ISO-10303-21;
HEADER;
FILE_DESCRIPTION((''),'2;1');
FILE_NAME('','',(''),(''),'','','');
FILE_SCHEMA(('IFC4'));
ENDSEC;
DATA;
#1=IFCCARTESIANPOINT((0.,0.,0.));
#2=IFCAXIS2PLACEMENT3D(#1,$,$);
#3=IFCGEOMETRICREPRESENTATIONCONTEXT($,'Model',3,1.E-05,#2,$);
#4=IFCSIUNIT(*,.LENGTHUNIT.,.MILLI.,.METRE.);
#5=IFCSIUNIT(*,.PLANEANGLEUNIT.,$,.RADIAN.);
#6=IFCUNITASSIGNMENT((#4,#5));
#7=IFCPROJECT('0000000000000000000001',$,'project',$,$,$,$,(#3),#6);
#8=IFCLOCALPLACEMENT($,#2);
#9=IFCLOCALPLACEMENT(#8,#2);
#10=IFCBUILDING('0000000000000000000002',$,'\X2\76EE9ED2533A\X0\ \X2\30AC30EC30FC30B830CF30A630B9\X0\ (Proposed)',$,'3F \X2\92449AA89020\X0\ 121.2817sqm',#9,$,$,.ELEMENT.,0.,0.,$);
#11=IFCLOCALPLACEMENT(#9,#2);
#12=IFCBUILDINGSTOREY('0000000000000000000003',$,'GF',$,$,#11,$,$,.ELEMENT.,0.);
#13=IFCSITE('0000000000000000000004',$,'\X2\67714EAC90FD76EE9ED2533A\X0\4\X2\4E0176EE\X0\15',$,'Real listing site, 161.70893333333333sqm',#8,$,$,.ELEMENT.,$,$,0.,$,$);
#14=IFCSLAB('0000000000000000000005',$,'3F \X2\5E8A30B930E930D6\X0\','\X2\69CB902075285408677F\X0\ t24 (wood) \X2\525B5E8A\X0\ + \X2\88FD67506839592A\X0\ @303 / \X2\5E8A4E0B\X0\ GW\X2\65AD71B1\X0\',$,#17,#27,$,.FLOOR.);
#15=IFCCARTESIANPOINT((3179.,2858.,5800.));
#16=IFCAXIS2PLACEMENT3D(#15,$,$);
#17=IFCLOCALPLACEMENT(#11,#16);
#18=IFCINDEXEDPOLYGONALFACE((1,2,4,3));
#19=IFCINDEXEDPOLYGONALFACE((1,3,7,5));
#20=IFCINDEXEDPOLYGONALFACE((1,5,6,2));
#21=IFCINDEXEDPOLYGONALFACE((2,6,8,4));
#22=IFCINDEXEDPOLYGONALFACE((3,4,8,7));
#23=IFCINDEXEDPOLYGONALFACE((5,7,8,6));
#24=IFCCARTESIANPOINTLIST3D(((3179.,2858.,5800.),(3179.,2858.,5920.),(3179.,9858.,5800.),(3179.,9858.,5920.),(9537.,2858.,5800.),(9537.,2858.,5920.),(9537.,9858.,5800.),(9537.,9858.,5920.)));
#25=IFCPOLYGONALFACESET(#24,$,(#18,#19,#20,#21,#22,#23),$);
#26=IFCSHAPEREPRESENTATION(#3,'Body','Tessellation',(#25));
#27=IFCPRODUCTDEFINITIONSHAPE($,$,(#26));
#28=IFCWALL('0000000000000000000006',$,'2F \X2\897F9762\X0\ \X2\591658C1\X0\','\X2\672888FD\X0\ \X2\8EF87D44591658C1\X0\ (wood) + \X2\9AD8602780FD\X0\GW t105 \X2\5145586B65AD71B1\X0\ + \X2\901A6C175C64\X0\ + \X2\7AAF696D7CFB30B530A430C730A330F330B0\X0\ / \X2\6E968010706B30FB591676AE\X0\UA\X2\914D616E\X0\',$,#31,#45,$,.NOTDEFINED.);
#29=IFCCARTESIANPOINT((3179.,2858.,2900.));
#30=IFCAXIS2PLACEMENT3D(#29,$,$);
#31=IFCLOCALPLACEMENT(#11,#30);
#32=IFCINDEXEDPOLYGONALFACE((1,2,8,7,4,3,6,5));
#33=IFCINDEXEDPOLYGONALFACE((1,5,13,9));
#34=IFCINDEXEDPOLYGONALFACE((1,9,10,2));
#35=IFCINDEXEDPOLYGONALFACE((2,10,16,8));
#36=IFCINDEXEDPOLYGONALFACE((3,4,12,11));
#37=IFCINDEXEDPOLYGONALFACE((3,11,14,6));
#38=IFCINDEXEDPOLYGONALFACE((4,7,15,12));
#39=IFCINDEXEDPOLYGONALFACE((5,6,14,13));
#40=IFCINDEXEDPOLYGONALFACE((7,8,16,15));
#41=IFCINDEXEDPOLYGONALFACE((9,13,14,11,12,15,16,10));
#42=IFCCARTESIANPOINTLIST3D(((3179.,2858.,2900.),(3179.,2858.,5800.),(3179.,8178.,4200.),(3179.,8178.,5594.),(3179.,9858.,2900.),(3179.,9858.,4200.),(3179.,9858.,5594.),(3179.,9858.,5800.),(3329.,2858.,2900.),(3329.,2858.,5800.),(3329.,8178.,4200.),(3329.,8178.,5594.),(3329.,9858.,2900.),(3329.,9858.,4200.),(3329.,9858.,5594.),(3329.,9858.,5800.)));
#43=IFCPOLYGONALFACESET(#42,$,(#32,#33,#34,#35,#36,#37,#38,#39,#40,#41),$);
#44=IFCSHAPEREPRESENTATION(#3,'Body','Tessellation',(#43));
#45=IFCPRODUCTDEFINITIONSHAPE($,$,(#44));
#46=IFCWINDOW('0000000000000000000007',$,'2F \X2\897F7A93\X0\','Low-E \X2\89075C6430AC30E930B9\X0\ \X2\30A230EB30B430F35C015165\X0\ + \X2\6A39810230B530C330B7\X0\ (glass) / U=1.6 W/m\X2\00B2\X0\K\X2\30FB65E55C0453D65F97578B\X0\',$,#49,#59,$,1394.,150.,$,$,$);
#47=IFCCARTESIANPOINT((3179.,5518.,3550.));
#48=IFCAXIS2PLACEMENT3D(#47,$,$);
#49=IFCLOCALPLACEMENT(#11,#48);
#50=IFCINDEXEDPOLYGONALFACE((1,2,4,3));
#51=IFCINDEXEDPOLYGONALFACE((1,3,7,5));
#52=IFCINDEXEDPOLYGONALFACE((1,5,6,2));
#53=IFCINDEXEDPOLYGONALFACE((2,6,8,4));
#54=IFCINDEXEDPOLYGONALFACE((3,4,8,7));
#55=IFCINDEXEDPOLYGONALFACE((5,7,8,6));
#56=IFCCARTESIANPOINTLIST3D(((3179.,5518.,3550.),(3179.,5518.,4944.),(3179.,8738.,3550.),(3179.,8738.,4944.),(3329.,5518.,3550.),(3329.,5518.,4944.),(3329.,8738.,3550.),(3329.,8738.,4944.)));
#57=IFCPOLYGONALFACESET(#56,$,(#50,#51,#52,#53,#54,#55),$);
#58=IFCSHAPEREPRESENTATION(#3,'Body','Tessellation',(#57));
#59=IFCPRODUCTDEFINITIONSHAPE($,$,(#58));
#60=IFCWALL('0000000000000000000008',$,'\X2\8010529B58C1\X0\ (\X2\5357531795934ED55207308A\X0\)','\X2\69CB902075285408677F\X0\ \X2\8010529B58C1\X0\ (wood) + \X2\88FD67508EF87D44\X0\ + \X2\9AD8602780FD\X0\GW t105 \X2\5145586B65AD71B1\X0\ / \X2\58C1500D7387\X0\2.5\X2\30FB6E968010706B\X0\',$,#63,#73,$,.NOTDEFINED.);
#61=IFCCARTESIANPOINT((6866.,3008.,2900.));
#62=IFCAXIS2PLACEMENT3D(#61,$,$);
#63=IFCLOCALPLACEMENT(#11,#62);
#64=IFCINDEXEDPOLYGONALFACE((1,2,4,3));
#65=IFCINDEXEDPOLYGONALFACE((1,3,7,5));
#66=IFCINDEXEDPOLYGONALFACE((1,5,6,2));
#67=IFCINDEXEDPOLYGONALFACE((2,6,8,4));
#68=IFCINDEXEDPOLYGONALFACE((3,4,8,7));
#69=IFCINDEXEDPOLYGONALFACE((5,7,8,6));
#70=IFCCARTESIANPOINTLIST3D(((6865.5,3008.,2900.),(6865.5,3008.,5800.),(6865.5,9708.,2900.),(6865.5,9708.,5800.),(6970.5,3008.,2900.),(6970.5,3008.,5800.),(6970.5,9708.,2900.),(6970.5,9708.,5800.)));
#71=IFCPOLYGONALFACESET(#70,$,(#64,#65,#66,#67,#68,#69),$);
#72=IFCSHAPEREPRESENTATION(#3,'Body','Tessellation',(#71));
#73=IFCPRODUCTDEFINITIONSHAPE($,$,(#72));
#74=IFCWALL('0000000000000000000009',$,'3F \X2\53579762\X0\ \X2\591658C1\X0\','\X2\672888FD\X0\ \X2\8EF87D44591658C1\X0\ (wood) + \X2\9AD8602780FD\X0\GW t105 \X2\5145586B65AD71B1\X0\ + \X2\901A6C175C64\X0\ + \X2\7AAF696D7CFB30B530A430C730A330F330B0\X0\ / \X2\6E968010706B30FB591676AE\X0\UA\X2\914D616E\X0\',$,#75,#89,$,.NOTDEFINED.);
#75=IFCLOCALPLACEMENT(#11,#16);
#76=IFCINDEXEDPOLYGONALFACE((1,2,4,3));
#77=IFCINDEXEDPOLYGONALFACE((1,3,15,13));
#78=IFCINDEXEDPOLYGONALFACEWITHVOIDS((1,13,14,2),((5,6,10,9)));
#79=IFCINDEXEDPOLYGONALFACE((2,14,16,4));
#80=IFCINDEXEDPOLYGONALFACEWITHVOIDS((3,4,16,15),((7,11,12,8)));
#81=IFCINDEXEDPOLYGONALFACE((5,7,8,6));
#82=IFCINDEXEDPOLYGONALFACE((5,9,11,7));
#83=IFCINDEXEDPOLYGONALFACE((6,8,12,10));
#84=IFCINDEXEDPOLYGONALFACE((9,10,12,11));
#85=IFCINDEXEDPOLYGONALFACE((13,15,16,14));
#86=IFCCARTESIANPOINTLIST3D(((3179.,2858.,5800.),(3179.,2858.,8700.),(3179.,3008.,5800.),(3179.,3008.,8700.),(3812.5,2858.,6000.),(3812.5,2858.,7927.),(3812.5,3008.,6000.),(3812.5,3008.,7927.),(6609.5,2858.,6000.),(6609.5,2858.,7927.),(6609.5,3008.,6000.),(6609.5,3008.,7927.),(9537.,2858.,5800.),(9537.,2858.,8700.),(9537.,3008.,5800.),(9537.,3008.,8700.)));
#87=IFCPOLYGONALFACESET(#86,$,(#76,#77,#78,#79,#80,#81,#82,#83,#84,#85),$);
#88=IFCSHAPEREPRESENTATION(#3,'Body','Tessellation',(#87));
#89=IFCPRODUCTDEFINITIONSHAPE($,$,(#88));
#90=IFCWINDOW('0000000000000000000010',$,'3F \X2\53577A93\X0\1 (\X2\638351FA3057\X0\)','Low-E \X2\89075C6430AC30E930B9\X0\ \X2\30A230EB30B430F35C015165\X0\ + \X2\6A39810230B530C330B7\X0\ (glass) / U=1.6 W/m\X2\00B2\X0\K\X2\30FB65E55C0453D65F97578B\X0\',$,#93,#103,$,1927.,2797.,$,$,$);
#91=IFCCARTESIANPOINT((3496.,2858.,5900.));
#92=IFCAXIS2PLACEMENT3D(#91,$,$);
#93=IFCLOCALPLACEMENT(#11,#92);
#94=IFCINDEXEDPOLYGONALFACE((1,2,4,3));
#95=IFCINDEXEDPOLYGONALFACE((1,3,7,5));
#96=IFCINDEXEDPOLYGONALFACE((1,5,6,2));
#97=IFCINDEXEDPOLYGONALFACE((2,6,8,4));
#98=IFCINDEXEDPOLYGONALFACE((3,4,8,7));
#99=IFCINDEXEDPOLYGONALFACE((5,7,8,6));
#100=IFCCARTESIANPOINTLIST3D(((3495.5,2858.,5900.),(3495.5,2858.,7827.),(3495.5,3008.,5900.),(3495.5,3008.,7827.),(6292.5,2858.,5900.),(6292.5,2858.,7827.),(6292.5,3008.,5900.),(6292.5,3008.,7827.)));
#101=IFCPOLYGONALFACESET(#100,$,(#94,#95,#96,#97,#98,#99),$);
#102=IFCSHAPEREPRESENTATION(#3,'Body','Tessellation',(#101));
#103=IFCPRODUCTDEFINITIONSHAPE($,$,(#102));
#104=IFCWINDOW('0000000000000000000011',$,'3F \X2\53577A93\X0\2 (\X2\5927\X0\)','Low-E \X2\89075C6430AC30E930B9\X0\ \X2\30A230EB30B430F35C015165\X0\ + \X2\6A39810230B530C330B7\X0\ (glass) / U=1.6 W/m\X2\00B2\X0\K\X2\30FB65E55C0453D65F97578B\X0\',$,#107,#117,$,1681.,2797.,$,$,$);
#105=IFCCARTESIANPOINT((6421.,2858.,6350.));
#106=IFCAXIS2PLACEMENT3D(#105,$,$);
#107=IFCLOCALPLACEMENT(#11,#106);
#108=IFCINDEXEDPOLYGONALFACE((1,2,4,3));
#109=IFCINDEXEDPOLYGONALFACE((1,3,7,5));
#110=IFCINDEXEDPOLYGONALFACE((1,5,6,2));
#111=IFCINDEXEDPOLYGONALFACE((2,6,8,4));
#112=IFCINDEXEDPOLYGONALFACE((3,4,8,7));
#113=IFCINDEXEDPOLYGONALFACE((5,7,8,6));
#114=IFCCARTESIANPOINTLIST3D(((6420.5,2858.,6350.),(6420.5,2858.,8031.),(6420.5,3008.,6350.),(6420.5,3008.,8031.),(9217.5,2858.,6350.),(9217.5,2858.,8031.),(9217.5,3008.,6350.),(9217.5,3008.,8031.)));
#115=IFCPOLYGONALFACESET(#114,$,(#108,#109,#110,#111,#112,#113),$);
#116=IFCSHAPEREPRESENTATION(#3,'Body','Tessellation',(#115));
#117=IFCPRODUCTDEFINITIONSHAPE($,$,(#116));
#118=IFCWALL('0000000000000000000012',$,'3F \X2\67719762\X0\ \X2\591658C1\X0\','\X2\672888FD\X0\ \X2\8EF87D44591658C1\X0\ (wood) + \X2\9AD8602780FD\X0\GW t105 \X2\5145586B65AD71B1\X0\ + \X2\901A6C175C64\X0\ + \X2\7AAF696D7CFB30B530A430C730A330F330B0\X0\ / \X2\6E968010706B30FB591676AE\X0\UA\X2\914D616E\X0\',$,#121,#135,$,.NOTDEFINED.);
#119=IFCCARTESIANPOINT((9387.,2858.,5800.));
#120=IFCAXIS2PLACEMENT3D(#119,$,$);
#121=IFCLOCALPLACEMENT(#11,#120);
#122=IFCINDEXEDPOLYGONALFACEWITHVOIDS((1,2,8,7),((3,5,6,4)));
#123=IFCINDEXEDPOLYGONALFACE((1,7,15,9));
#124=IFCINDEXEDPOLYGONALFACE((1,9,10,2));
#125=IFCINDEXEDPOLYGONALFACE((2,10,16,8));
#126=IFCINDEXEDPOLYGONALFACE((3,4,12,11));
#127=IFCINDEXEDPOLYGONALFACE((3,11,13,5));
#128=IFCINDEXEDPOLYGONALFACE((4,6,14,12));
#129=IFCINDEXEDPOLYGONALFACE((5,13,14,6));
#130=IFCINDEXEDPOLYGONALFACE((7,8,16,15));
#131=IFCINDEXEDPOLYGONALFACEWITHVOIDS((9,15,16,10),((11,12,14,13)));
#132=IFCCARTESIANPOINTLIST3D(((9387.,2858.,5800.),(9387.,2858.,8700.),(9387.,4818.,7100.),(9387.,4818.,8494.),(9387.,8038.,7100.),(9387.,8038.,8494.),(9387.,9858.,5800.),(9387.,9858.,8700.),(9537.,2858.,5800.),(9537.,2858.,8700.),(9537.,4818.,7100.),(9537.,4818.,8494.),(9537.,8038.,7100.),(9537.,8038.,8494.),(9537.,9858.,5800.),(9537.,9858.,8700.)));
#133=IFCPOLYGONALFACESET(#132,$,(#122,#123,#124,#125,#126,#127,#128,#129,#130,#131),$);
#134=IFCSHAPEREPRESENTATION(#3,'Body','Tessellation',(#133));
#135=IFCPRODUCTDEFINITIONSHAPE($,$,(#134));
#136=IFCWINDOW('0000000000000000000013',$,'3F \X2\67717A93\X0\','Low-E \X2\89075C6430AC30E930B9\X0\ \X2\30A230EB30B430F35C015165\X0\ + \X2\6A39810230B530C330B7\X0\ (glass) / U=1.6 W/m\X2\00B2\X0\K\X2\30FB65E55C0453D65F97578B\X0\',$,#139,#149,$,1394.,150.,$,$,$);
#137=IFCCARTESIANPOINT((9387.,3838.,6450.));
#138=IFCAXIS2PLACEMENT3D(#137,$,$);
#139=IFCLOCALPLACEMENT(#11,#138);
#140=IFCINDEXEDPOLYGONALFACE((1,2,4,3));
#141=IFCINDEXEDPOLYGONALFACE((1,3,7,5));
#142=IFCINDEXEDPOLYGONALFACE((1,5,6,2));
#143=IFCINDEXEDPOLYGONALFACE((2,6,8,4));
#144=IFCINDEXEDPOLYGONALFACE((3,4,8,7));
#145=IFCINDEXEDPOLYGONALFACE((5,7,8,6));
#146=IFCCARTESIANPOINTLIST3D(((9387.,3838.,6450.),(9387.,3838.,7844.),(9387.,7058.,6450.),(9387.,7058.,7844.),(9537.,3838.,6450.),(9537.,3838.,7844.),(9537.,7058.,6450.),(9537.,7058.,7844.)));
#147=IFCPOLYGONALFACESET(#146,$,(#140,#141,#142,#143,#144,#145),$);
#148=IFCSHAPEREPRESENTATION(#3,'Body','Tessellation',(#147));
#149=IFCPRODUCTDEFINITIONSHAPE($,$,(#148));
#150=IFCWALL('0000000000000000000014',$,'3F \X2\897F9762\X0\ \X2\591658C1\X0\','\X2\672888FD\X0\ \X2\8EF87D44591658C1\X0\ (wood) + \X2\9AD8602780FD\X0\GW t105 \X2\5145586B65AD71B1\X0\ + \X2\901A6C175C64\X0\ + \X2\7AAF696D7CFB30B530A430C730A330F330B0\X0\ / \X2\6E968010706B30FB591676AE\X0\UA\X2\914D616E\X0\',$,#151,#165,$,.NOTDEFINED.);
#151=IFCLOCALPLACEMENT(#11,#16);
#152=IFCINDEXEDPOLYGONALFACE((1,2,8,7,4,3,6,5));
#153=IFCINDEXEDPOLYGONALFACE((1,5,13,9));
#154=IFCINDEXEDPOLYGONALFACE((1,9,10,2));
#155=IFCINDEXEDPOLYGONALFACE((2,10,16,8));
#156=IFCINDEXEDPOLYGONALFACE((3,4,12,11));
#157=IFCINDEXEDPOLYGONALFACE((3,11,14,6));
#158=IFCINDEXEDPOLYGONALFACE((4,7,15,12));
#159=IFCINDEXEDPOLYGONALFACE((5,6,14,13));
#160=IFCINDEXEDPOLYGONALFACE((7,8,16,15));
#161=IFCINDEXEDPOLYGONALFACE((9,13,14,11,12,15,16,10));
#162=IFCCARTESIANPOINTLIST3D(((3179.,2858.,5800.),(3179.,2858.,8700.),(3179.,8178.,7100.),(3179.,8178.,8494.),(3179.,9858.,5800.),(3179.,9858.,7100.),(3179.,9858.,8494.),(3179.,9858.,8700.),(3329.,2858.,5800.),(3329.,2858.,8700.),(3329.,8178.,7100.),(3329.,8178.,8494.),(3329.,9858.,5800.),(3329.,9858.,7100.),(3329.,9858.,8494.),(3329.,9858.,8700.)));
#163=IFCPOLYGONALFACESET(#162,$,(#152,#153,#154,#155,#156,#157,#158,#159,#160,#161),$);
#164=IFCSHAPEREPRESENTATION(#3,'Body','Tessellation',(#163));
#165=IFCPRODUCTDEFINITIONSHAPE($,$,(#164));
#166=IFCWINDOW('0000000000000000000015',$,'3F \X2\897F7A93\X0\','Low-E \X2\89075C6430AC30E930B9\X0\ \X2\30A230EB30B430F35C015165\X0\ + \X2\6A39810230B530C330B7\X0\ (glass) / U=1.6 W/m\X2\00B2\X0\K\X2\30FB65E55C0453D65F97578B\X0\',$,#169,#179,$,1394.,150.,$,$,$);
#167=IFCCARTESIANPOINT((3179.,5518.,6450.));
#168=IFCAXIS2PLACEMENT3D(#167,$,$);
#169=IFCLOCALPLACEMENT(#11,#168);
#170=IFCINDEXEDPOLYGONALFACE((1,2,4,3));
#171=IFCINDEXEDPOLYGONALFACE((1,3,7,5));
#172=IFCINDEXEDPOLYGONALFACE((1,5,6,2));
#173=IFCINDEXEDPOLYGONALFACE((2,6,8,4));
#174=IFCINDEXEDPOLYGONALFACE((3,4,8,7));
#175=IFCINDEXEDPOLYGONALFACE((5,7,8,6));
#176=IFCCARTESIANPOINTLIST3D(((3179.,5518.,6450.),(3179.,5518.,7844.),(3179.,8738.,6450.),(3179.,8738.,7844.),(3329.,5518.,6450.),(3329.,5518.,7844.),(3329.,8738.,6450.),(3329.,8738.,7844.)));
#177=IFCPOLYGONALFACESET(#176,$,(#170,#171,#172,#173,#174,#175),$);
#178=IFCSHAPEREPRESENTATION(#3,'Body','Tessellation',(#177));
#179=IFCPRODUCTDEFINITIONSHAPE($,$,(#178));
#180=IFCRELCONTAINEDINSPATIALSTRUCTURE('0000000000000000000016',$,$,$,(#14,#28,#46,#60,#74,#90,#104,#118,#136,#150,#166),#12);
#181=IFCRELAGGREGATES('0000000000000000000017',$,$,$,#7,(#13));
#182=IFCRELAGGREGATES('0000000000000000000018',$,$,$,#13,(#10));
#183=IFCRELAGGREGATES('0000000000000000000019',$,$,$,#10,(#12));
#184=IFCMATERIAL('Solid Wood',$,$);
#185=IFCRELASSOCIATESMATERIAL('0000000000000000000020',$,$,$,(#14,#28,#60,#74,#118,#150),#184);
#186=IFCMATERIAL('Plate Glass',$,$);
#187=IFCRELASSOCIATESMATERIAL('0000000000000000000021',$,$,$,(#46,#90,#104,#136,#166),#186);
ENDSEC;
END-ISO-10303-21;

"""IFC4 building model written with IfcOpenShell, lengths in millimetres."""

from ifc_helpers import new_model, si_unit, frame, frame_2d, origin, place, context, project, spatial, rectangle, extrude, material, element, fill, save


model = new_model("IFC4")

# Units and contexts
model_context = context("Model", 3, precision=1e-05, world=origin())
ifc_project = project(units=[si_unit("LENGTHUNIT", "METRE", prefix="MILLI"), si_unit("PLANEANGLEUNIT", "RADIAN")], contexts=[model_context])

# Site, building, storey
site_placement = place(None, origin())
site = spatial("IfcSite", under=ifc_project, at=site_placement, Name="東京都目黒区4丁目15", ObjectType="Real listing site, 161.70893333333333sqm", CompositionType="ELEMENT", RefElevation=0.0)
building_placement = place(site_placement, origin())
building = spatial("IfcBuilding", under=site, at=building_placement, Name="目黒区 ガレージハウス (Proposed)", ObjectType="3F 鉄骨造 121.2817sqm", CompositionType="ELEMENT", ElevationOfRefHeight=0.0, ElevationOfTerrain=0.0)
storey_placement = place(building_placement, origin())
storey = spatial("IfcBuildingStorey", under=building, at=storey_placement, Name="GF", CompositionType="ELEMENT", Elevation=0.0)

# Slab
ifc_material_1 = material(Name="Solid Wood")
slab_placement = place(storey_placement, frame((3179.0, 2858.0, 5800.0)))
element("IfcSlab", 1, at=slab_placement, inside=storey, material=ifc_material_1, Name="3F 床スラブ", Description="構造用合板 t24 (wood) 剛床 + 製材根太 @303 / 床下 GW断熱", PredefinedType="FLOOR", context=model_context, shape_type="SweptSolid", body=[
    extrude(rectangle(XDim=6358.0, YDim=7000.0, at=frame_2d((3179.0, 3500.0))), frame((3179.0, 2858.0, 5800.0)), (0.0, 0.0, 1.0), 120.0),
])

# Wall, opening, window
wall_1_placement = place(storey_placement, frame((3179.0, 2858.0, 2900.0)))
wall_1 = element("IfcWall", 2, at=wall_1_placement, inside=storey, material=ifc_material_1, Name="2F 西面 外壁", Description="木製 軸組外壁 (wood) + 高性能GW t105 充填断熱 + 通気層 + 窯業系サイディング / 準耐火・外皮UA配慮", PredefinedType="NOTDEFINED", context=model_context, shape_type="SweptSolid", body=[
    extrude(rectangle(XDim=150.0, YDim=7000.0, at=frame_2d((75.0, 3500.0))), frame((3179.0, 2858.0, 2900.0)), (0.0, 0.0, 1.0), 2900.0),
])
opening_1_placement = place(storey_placement, frame((3179.0, 5518.0, 3550.0)))
opening_1 = element("IfcOpeningElement", 3, at=opening_1_placement, cuts=wall_1, PredefinedType="NOTDEFINED", context=model_context, shape_type="SweptSolid", body=[
    extrude(rectangle(XDim=150.0, YDim=3220.0, at=frame_2d((75.0, 1610.0))), frame((3179.0, 5518.0, 3550.0)), (0.0, 0.0, 1.0), 1394.0),
])
ifc_material_2 = material(Name="Plate Glass")
window_1_placement = place(storey_placement, frame((3179.0, 5518.0, 3550.0)))
window_1 = element("IfcWindow", 4, at=window_1_placement, inside=storey, material=ifc_material_2, Name="2F 西窓", Description="Low-E 複層ガラス アルゴン封入 + 樹脂サッシ (glass) / U=1.6 W/m²K・日射取得型", OverallHeight=1394.0, OverallWidth=150.0, context=model_context, shape_type="SweptSolid", body=[
    extrude(rectangle(XDim=150.0, YDim=3220.0, at=frame_2d((75.0, 1610.0))), frame((3179.0, 5518.0, 3550.0)), (0.0, 0.0, 1.0), 1394.0),
])
fill(opening_1, window_1)

# Wall
wall_2_placement = place(storey_placement, frame((6866.0, 3008.0, 2900.0)))
element("IfcWall", 5, at=wall_2_placement, inside=storey, material=ifc_material_1, Name="耐力壁 (南北間仕切り)", Description="構造用合板 耐力壁 (wood) + 製材軸組 + 高性能GW t105 充填断熱 / 壁倍率2.5・準耐火", PredefinedType="NOTDEFINED", context=model_context, shape_type="SweptSolid", body=[
    extrude(rectangle(XDim=105.0, YDim=6700.0, at=frame_2d((52.0, 3350.0))), frame((6866.0, 3008.0, 2900.0)), (0.0, 0.0, 1.0), 2900.0),
])

# Wall, openings, windows
wall_3_placement = place(storey_placement, frame((3179.0, 2858.0, 5800.0)))
wall_3 = element("IfcWall", 6, at=wall_3_placement, inside=storey, material=ifc_material_1, Name="3F 南面 外壁", Description="木製 軸組外壁 (wood) + 高性能GW t105 充填断熱 + 通気層 + 窯業系サイディング / 準耐火・外皮UA配慮", PredefinedType="NOTDEFINED", context=model_context, shape_type="SweptSolid", body=[
    extrude(rectangle(XDim=6358.0, YDim=150.0, at=frame_2d((3179.0, 75.0))), frame((3179.0, 2858.0, 5800.0)), (0.0, 0.0, 1.0), 2900.0),
])
opening_2_placement = place(storey_placement, frame((3496.0, 2858.0, 5900.0)))
opening_2 = element("IfcOpeningElement", 7, at=opening_2_placement, cuts=wall_3, PredefinedType="NOTDEFINED", context=model_context, shape_type="SweptSolid", body=[
    extrude(rectangle(XDim=2797.0, YDim=150.0, at=frame_2d((1398.0, 75.0))), frame((3496.0, 2858.0, 5900.0)), (0.0, 0.0, 1.0), 1927.0),
])
opening_3_placement = place(storey_placement, frame((6421.0, 2858.0, 6350.0)))
opening_3 = element("IfcOpeningElement", 8, at=opening_3_placement, cuts=wall_3, PredefinedType="NOTDEFINED", context=model_context, shape_type="SweptSolid", body=[
    extrude(rectangle(XDim=2797.0, YDim=150.0, at=frame_2d((1398.0, 75.0))), frame((6421.0, 2858.0, 6350.0)), (0.0, 0.0, 1.0), 1681.0),
])
window_2_placement = place(storey_placement, frame((3496.0, 2858.0, 5900.0)))
window_2 = element("IfcWindow", 9, at=window_2_placement, inside=storey, material=ifc_material_2, Name="3F 南窓1 (掃出し)", Description="Low-E 複層ガラス アルゴン封入 + 樹脂サッシ (glass) / U=1.6 W/m²K・日射取得型", OverallHeight=1927.0, OverallWidth=2797.0, context=model_context, shape_type="SweptSolid", body=[
    extrude(rectangle(XDim=2797.0, YDim=150.0, at=frame_2d((1398.0, 75.0))), frame((3496.0, 2858.0, 5900.0)), (0.0, 0.0, 1.0), 1927.0),
])
fill(opening_2, window_2)
window_3_placement = place(storey_placement, frame((6421.0, 2858.0, 6350.0)))
window_3 = element("IfcWindow", 10, at=window_3_placement, inside=storey, material=ifc_material_2, Name="3F 南窓2 (大)", Description="Low-E 複層ガラス アルゴン封入 + 樹脂サッシ (glass) / U=1.6 W/m²K・日射取得型", OverallHeight=1681.0, OverallWidth=2797.0, context=model_context, shape_type="SweptSolid", body=[
    extrude(rectangle(XDim=2797.0, YDim=150.0, at=frame_2d((1398.0, 75.0))), frame((6421.0, 2858.0, 6350.0)), (0.0, 0.0, 1.0), 1681.0),
])
fill(opening_3, window_3)

# Walls, openings, windows
wall_4_placement = place(storey_placement, frame((9387.0, 2858.0, 5800.0)))
wall_4 = element("IfcWall", 11, at=wall_4_placement, inside=storey, material=ifc_material_1, Name="3F 東面 外壁", Description="木製 軸組外壁 (wood) + 高性能GW t105 充填断熱 + 通気層 + 窯業系サイディング / 準耐火・外皮UA配慮", PredefinedType="NOTDEFINED", context=model_context, shape_type="SweptSolid", body=[
    extrude(rectangle(XDim=150.0, YDim=7000.0, at=frame_2d((75.0, 3500.0))), frame((9387.0, 2858.0, 5800.0)), (0.0, 0.0, 1.0), 2900.0),
])
opening_4_placement = place(storey_placement, frame((9387.0, 3838.0, 6450.0)))
opening_4 = element("IfcOpeningElement", 12, at=opening_4_placement, cuts=wall_4, PredefinedType="NOTDEFINED", context=model_context, shape_type="SweptSolid", body=[
    extrude(rectangle(XDim=150.0, YDim=3220.0, at=frame_2d((75.0, 1610.0))), frame((9387.0, 3838.0, 6450.0)), (0.0, 0.0, 1.0), 1394.0),
])
window_4_placement = place(storey_placement, frame((9387.0, 3838.0, 6450.0)))
window_4 = element("IfcWindow", 13, at=window_4_placement, inside=storey, material=ifc_material_2, Name="3F 東窓", Description="Low-E 複層ガラス アルゴン封入 + 樹脂サッシ (glass) / U=1.6 W/m²K・日射取得型", OverallHeight=1394.0, OverallWidth=150.0, context=model_context, shape_type="SweptSolid", body=[
    extrude(rectangle(XDim=150.0, YDim=3220.0, at=frame_2d((75.0, 1610.0))), frame((9387.0, 3838.0, 6450.0)), (0.0, 0.0, 1.0), 1394.0),
])
fill(opening_4, window_4)
wall_5_placement = place(storey_placement, frame((3179.0, 2858.0, 5800.0)))
wall_5 = element("IfcWall", 14, at=wall_5_placement, inside=storey, material=ifc_material_1, Name="3F 西面 外壁", Description="木製 軸組外壁 (wood) + 高性能GW t105 充填断熱 + 通気層 + 窯業系サイディング / 準耐火・外皮UA配慮", PredefinedType="NOTDEFINED", context=model_context, shape_type="SweptSolid", body=[
    extrude(rectangle(XDim=150.0, YDim=7000.0, at=frame_2d((75.0, 3500.0))), frame((3179.0, 2858.0, 5800.0)), (0.0, 0.0, 1.0), 2900.0),
])
opening_5_placement = place(storey_placement, frame((3179.0, 5518.0, 6450.0)))
opening_5 = element("IfcOpeningElement", 15, at=opening_5_placement, cuts=wall_5, PredefinedType="NOTDEFINED", context=model_context, shape_type="SweptSolid", body=[
    extrude(rectangle(XDim=150.0, YDim=3220.0, at=frame_2d((75.0, 1610.0))), frame((3179.0, 5518.0, 6450.0)), (0.0, 0.0, 1.0), 1394.0),
])
window_5_placement = place(storey_placement, frame((3179.0, 5518.0, 6450.0)))
window_5 = element("IfcWindow", 16, at=window_5_placement, inside=storey, material=ifc_material_2, Name="3F 西窓", Description="Low-E 複層ガラス アルゴン封入 + 樹脂サッシ (glass) / U=1.6 W/m²K・日射取得型", OverallHeight=1394.0, OverallWidth=150.0, context=model_context, shape_type="SweptSolid", body=[
    extrude(rectangle(XDim=150.0, YDim=3220.0, at=frame_2d((75.0, 1610.0))), frame((3179.0, 5518.0, 6450.0)), (0.0, 0.0, 1.0), 1394.0),
])
fill(opening_5, window_5)

save(model, "model.ifc")
